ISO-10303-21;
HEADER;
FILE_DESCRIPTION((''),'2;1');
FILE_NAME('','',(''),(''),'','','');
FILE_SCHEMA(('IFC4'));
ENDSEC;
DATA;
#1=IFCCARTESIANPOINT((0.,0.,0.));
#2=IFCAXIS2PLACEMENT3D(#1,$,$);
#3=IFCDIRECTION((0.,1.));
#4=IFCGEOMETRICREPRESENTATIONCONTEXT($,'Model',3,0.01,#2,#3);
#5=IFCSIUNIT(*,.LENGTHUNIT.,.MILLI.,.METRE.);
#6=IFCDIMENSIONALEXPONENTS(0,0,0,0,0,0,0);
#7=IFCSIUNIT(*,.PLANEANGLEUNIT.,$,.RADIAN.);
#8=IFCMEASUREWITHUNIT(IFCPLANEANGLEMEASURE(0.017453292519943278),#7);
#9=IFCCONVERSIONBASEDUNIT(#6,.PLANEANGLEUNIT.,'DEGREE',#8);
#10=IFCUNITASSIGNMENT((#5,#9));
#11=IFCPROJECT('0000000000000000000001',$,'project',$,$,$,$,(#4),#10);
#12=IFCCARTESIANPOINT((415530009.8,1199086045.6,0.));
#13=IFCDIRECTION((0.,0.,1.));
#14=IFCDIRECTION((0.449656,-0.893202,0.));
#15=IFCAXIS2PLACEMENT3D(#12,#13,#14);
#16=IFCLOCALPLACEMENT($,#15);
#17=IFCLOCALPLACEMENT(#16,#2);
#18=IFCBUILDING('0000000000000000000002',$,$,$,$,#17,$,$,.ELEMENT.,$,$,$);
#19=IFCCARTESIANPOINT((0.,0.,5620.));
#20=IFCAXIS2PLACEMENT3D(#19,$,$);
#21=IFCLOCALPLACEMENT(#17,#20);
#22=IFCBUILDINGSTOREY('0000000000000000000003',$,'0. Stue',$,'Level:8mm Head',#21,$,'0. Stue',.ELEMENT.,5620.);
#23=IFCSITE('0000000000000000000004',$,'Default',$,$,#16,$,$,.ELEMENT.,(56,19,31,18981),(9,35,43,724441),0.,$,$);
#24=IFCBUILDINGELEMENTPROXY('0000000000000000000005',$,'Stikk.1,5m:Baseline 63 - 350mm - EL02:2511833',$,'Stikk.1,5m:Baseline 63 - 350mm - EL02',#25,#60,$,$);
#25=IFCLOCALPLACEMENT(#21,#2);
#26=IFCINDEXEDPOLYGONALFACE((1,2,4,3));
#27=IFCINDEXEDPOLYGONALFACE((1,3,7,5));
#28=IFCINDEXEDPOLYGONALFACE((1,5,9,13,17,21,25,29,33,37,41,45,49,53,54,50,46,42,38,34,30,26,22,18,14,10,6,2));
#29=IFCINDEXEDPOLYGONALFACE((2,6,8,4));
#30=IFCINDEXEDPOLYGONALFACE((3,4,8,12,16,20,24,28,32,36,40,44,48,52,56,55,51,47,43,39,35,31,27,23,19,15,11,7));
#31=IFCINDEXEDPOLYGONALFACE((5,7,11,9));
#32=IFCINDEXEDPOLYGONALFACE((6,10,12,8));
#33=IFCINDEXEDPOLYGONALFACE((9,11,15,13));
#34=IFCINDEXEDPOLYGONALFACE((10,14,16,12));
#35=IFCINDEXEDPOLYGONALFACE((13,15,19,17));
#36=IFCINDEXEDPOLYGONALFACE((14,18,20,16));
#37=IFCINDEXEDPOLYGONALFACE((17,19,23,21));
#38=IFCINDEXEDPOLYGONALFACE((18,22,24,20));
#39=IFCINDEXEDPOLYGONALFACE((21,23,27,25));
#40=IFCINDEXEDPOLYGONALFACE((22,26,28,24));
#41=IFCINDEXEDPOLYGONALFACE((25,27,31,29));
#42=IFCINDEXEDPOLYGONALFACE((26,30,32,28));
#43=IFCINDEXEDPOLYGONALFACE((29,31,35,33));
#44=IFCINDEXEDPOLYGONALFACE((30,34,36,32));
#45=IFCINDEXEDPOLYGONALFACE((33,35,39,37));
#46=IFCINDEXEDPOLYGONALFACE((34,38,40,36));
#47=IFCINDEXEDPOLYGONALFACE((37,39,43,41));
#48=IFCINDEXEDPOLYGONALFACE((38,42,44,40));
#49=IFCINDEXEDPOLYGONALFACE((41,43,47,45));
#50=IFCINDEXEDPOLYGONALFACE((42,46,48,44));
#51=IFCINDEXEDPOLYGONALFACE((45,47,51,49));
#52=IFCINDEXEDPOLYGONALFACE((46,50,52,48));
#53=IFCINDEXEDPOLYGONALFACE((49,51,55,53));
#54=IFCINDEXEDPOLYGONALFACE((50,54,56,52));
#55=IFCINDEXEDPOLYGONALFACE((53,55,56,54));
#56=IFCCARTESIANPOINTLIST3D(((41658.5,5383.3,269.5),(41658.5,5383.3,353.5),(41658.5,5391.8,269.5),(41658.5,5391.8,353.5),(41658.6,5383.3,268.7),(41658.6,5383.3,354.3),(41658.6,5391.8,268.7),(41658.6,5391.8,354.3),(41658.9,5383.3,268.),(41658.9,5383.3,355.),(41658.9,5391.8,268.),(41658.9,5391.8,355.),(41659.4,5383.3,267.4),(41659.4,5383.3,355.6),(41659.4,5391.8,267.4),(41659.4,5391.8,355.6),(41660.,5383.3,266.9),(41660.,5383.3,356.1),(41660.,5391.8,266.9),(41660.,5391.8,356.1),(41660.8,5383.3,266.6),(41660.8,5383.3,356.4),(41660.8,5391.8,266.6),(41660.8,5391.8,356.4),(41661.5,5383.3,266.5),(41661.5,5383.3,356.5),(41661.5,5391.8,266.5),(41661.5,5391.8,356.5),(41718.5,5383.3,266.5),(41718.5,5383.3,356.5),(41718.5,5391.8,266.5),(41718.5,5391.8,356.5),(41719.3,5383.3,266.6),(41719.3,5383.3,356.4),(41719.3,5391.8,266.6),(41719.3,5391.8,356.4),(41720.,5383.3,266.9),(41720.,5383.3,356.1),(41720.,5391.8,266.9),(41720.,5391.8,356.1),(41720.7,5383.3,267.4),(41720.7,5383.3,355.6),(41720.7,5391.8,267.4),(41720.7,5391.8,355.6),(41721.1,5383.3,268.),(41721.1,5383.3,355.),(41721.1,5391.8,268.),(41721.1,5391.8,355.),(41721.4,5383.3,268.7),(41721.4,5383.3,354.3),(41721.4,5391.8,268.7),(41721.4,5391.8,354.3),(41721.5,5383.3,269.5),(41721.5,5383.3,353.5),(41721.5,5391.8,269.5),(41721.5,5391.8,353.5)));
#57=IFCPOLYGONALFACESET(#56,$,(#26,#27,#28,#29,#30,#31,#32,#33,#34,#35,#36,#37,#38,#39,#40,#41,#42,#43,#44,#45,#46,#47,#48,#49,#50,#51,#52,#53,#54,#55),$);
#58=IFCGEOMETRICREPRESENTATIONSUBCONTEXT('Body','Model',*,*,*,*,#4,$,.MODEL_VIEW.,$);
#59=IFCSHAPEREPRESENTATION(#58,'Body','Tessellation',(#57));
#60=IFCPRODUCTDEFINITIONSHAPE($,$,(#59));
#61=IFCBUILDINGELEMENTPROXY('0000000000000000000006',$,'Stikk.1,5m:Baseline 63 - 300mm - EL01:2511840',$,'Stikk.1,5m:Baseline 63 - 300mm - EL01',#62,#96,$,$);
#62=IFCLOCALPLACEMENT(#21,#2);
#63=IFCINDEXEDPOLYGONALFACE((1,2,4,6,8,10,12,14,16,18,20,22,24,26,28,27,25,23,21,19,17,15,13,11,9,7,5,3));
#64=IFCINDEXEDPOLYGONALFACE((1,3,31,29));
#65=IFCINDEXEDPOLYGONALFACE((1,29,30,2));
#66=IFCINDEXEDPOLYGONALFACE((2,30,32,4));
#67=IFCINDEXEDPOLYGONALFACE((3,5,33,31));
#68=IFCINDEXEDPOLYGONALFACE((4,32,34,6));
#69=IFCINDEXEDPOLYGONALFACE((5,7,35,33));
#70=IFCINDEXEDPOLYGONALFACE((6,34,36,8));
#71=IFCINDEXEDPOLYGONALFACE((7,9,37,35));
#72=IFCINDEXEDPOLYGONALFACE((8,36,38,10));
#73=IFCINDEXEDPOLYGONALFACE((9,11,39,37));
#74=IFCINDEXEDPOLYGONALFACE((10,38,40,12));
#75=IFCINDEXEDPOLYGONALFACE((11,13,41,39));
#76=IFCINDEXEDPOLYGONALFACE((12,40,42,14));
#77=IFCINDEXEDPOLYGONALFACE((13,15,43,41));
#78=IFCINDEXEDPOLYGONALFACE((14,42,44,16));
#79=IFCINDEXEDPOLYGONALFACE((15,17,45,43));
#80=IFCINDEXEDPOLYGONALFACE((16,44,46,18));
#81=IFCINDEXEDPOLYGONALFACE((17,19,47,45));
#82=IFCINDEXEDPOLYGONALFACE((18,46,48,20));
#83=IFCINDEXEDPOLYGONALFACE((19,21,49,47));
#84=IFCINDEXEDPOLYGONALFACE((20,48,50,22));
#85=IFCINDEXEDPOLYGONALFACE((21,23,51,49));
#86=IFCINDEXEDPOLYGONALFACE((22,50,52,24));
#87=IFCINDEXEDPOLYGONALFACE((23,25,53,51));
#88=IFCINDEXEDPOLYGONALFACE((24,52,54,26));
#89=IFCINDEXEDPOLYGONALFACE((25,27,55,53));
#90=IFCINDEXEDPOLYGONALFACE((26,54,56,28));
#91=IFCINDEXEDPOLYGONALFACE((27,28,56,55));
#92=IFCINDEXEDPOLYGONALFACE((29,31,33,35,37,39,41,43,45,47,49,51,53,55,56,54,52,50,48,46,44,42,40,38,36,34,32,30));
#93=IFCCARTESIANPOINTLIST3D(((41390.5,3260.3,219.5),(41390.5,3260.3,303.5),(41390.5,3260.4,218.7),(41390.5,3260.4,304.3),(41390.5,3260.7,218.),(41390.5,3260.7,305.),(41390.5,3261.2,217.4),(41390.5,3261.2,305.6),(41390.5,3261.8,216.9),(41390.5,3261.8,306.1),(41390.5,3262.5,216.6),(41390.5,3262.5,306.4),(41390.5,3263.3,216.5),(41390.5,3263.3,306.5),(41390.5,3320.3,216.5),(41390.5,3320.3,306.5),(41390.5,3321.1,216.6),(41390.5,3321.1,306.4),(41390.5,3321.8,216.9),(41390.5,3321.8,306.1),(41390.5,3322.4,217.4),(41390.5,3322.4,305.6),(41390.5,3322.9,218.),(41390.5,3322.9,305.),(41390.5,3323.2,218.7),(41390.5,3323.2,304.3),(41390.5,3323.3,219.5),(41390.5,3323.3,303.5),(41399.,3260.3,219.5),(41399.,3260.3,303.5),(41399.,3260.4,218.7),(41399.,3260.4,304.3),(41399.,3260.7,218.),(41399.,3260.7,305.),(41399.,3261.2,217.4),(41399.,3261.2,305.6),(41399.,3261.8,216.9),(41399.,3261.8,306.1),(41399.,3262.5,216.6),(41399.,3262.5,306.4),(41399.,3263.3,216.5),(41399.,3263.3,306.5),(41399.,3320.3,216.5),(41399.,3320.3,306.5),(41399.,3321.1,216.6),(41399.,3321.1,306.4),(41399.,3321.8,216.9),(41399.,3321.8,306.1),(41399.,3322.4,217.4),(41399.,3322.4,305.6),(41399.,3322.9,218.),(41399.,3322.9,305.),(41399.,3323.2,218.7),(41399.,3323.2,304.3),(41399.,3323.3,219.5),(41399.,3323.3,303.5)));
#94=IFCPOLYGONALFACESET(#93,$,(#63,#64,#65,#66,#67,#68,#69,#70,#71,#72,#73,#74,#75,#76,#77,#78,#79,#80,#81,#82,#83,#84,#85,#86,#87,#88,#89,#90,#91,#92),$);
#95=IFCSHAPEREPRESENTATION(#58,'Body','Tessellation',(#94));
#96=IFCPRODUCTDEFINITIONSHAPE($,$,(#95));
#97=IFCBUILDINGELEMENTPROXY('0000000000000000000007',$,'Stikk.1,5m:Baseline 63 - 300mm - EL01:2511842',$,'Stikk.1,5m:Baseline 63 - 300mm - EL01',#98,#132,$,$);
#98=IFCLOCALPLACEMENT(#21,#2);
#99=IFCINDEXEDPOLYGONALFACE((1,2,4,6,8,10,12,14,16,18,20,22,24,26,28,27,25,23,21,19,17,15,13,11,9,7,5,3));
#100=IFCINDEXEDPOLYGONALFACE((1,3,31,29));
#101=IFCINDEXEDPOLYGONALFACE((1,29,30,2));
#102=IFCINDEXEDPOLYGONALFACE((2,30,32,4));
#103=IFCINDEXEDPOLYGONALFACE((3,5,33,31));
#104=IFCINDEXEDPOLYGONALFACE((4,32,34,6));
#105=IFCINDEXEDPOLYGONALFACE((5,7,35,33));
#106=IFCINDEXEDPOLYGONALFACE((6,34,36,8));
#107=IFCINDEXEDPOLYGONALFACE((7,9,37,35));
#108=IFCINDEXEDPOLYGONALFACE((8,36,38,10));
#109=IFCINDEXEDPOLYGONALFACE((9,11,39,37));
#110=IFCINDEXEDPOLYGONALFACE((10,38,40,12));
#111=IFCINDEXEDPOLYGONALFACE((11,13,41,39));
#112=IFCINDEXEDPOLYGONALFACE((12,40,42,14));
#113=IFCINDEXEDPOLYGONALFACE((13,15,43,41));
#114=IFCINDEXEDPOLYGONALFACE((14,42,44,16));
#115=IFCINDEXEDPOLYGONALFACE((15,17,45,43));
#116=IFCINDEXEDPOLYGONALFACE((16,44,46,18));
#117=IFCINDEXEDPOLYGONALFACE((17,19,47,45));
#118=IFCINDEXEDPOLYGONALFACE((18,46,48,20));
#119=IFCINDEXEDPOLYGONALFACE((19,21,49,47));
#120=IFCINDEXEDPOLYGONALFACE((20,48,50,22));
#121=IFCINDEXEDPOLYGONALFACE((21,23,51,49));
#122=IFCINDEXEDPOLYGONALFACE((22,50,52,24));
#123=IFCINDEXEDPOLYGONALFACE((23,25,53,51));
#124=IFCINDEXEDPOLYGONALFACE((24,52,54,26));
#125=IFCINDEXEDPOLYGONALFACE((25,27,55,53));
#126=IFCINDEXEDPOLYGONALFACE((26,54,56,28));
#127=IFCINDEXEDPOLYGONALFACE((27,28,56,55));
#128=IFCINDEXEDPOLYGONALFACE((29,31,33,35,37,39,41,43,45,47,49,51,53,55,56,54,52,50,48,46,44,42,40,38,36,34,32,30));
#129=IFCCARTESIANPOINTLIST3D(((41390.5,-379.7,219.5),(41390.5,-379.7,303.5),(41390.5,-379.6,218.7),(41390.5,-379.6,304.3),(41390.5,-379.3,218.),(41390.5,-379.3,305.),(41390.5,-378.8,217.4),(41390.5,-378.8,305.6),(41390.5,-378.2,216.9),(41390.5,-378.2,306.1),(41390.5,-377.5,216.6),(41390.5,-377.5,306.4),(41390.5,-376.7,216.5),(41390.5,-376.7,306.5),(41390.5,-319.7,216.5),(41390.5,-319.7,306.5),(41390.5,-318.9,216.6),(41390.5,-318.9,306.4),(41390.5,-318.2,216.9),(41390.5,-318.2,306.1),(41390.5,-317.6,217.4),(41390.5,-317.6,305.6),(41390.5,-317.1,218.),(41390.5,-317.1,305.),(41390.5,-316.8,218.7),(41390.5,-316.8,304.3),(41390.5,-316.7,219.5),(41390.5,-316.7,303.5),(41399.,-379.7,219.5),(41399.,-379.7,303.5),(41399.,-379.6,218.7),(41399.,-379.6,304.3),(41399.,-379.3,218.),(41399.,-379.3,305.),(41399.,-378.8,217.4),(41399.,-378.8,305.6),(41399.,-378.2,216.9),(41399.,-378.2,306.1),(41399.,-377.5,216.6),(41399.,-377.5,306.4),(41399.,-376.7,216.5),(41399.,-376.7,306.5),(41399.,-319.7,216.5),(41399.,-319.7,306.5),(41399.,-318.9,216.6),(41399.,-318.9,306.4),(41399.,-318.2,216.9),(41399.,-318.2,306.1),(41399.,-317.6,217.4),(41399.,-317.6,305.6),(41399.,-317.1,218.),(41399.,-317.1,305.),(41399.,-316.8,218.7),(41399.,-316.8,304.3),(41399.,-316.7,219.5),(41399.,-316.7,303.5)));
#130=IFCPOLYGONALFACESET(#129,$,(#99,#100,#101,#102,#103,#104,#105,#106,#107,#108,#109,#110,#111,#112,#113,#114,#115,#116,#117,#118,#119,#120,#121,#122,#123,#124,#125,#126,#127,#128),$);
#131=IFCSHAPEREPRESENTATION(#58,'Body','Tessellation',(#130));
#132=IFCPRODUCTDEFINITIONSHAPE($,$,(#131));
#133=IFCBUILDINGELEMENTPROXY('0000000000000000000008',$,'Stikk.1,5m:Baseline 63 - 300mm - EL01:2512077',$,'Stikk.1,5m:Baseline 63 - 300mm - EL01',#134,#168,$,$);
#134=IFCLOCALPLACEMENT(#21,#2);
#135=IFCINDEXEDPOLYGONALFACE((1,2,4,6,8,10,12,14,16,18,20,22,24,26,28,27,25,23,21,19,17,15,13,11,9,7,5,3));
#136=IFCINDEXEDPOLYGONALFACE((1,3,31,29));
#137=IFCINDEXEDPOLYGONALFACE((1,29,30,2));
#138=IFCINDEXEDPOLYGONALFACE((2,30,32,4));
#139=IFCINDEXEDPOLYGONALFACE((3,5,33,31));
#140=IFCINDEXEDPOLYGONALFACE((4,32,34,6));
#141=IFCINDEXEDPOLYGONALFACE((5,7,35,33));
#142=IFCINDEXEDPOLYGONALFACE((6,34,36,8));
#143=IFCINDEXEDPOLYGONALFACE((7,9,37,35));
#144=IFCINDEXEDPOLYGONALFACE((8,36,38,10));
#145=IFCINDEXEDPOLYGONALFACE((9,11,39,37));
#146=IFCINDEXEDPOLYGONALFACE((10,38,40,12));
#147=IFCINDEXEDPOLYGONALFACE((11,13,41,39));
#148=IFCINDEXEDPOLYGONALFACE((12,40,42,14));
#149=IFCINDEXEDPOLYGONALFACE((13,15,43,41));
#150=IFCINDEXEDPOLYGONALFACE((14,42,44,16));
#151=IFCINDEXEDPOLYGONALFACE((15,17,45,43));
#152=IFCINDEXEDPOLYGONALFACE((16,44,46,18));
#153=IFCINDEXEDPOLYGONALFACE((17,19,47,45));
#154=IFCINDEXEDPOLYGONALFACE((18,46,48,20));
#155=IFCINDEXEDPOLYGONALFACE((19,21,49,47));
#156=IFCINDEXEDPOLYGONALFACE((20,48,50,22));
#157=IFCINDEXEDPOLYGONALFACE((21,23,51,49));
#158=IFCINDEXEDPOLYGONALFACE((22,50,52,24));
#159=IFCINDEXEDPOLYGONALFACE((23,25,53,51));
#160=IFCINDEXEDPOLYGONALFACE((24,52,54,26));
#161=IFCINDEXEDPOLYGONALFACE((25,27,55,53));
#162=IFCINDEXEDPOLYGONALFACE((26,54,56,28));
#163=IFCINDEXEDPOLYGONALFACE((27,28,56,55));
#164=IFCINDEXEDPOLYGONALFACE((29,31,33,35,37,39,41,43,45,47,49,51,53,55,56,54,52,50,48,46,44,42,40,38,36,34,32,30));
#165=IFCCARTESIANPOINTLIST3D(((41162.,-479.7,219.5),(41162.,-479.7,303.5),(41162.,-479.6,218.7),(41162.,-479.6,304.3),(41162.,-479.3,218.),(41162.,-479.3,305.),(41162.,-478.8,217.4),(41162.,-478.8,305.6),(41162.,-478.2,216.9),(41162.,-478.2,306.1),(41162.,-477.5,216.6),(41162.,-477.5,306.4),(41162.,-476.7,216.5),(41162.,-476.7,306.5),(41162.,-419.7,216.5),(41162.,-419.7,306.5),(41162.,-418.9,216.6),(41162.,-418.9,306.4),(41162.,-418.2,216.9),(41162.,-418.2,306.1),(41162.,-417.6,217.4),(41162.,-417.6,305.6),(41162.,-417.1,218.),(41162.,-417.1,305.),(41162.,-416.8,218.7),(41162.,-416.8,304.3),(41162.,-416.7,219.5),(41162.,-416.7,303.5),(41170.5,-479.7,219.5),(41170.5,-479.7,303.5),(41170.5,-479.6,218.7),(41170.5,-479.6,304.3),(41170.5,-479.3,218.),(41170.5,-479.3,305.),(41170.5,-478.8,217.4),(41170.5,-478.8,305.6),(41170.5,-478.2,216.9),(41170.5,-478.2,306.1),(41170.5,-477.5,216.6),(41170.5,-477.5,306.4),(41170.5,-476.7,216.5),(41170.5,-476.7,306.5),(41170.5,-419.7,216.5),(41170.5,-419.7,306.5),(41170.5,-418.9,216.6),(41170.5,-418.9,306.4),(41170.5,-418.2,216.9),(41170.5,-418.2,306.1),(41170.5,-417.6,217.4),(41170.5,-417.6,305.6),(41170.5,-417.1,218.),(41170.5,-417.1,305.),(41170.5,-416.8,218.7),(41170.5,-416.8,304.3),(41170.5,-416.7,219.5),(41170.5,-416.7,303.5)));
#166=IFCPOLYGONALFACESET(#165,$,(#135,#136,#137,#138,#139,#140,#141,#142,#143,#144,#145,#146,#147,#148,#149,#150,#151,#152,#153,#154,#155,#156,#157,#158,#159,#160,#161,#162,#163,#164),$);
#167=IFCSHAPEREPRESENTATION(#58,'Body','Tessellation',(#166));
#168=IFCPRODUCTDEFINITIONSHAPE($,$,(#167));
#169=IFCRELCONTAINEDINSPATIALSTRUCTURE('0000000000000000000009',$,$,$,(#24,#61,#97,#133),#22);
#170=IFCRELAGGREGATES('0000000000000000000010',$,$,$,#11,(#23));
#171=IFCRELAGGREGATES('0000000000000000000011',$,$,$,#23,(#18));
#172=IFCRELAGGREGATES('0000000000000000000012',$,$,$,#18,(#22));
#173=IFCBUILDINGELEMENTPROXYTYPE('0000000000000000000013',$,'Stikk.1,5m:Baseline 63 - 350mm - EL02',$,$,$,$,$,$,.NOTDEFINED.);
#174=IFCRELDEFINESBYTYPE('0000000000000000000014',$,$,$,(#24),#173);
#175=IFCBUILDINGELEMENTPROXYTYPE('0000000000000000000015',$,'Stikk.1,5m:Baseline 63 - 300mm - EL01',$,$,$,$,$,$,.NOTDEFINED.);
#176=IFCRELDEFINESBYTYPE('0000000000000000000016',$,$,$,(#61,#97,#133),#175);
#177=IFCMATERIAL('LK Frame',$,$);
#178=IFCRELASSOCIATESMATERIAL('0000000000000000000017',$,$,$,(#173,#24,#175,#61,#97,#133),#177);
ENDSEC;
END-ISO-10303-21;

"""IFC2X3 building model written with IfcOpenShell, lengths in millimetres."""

from ifc_helpers import new_model, entity, si_unit, converted_unit, direction, frame, frame_2d, origin, place, context, subcontext, project, spatial, polyline, circle_curve, parameter, trimmed, segment, composite_curve, outline, extrude, source, transform, mapped, material, type_object, type_shapes, element, save


model = new_model("IFC2X3")

# Units and contexts
model_context = context("Model", 3, precision=0.01, world=origin(), true_north=direction((0.0, 1.0)))
body_context = subcontext(model_context, "Body", "Model", "MODEL_VIEW")
ifc_project = project(units=[si_unit("LENGTHUNIT", "METRE", prefix="MILLI"), converted_unit("PLANEANGLEUNIT", "DEGREE", entity("IfcPlaneAngleMeasure", 0.017453292519943278), si_unit("PLANEANGLEUNIT", "RADIAN"), dimensions=[0, 0, 0, 0, 0, 0, 0])], contexts=[model_context])

# Site, building, storey
site_placement = place(None, frame((415530009.8, 1199086045.6, 0.0), z_axis=(0.0, 0.0, 1.0), x_axis=(0.449656, -0.893202, 0.0)))
site = spatial("IfcSite", under=ifc_project, at=site_placement, Name="Default", CompositionType="ELEMENT", RefLatitude=(56, 19, 31, 18981), RefLongitude=(9, 35, 43, 724441), RefElevation=0.0)
building_placement = place(site_placement, origin())
building = spatial("IfcBuilding", under=site, at=building_placement, CompositionType="ELEMENT")
storey_placement = place(building_placement, frame((0.0, 0.0, 5620.0)))
storey = spatial("IfcBuildingStorey", under=building, at=storey_placement, Name="0. Stue", ObjectType="Level:8mm Head", LongName="0. Stue", CompositionType="ELEMENT", Elevation=5620.0)

# Building element proxies
ifc_material_1 = material(Name="LK Frame")
building_element_proxy_type_1 = type_object("IfcBuildingElementProxyType", Name="Stikk.1,5m:Baseline 63 - 350mm - EL02", PredefinedType="NOTDEFINED", material=ifc_material_1)
shared_shape_1 = source(origin(), body_context, "Body", "SweptSolid", [
    extrude(outline(composite_curve([segment(trimmed(circle_curve(frame_2d((-42.0, 28.5), x_axis=(1.0, 0.0)), 3.0), [parameter(90.0)], [parameter(180.0)], True, "PARAMETER"), True, "CONTINUOUS"), segment(polyline([(-45.0, 28.5), (-45.0, -28.5)]), True, "CONTINUOUS"), segment(trimmed(circle_curve(frame_2d((-42.0, -28.5), x_axis=(1.0, 0.0)), 3.0), [parameter(180.0)], [parameter(270.0)], True, "PARAMETER"), True, "CONTINUOUS"), segment(polyline([(-42.0, -31.5), (42.0, -31.5)]), True, "CONTINUOUS"), segment(trimmed(circle_curve(frame_2d((42.0, -28.5), x_axis=(-1.0, 0.0)), 3.0), [parameter(90.0)], [parameter(180.0)], True, "PARAMETER"), True, "CONTINUOUS"), segment(polyline([(45.0, -28.5), (45.0, 28.5)]), True, "CONTINUOUS"), segment(trimmed(circle_curve(frame_2d((42.0, 28.5), x_axis=(-1.0, 0.0)), 3.0), [parameter(180.0)], [parameter(270.0)], True, "PARAMETER"), True, "CONTINUOUS"), segment(polyline([(42.0, 31.5), (-42.0, 31.5)]), True, "CONTINUOUS")], self_intersect=False)), frame((0.0, 38.5, 0.0), z_axis=(0.0, 0.0, 1.0), x_axis=(0.0, -1.0, 0.0)), (0.0, 0.0, 1.0), 8.5),
])
type_shapes(building_element_proxy_type_1, [shared_shape_1])
proxy_1_placement = place(storey_placement, frame((41690.0, 5391.8, 350.0), z_axis=(0.0, -1.0, 0.0), x_axis=(-1.0, 0.0, 0.0)))
element("IfcBuildingElementProxy", 1, at=proxy_1_placement, inside=storey, type_object=building_element_proxy_type_1, material=ifc_material_1, Name="Stikk.1,5m:Baseline 63 - 350mm - EL02:2511833", ObjectType="Stikk.1,5m:Baseline 63 - 350mm - EL02", context=body_context, shape_type="MappedRepresentation", body=[
    mapped(shared_shape_1, transform((0.0, 0.0, 0.0), scale=1.0)),
])
building_element_proxy_type_2 = type_object("IfcBuildingElementProxyType", Name="Stikk.1,5m:Baseline 63 - 300mm - EL01", PredefinedType="NOTDEFINED", material=ifc_material_1)
shared_shape_2 = source(origin(), body_context, "Body", "SweptSolid", [
    extrude(outline(composite_curve([segment(trimmed(circle_curve(frame_2d((-42.0, 28.5), x_axis=(1.0, 0.0)), 3.0), [parameter(90.0)], [parameter(180.0)], True, "PARAMETER"), True, "CONTINUOUS"), segment(polyline([(-45.0, 28.5), (-45.0, -28.5)]), True, "CONTINUOUS"), segment(trimmed(circle_curve(frame_2d((-42.0, -28.5), x_axis=(1.0, 0.0)), 3.0), [parameter(180.0)], [parameter(270.0)], True, "PARAMETER"), True, "CONTINUOUS"), segment(polyline([(-42.0, -31.5), (42.0, -31.5)]), True, "CONTINUOUS"), segment(trimmed(circle_curve(frame_2d((42.0, -28.5), x_axis=(-1.0, 0.0)), 3.0), [parameter(90.0)], [parameter(180.0)], True, "PARAMETER"), True, "CONTINUOUS"), segment(polyline([(45.0, -28.5), (45.0, 28.5)]), True, "CONTINUOUS"), segment(trimmed(circle_curve(frame_2d((42.0, 28.5), x_axis=(-1.0, 0.0)), 3.0), [parameter(180.0)], [parameter(270.0)], True, "PARAMETER"), True, "CONTINUOUS"), segment(polyline([(42.0, 31.5), (-42.0, 31.5)]), True, "CONTINUOUS")], self_intersect=False)), frame((0.0, 38.5, 0.0), z_axis=(0.0, 0.0, 1.0), x_axis=(0.0, -1.0, 0.0)), (0.0, 0.0, 1.0), 8.5),
])
type_shapes(building_element_proxy_type_2, [shared_shape_2])
for number, where, z_axis, x_axis, name in (
    (2, (41390.5, 3291.8, 300.0), (1.0, 0.0, 0.0), (0.0, -1.0, 0.0), "Stikk.1,5m:Baseline 63 - 300mm - EL01:2511840"),
    (3, (41390.5, -348.2, 300.0), (1.0, 0.0, 0.0), (0.0, -1.0, 0.0), "Stikk.1,5m:Baseline 63 - 300mm - EL01:2511842"),
    (4, (41170.5, -448.2, 300.0), (-1.0, 0.0, 0.0), (0.0, 1.0, 0.0), "Stikk.1,5m:Baseline 63 - 300mm - EL01:2512077"),
):
    element("IfcBuildingElementProxy", number, at=place(storey_placement, frame(where, z_axis=z_axis, x_axis=x_axis)), inside=storey, type_object=building_element_proxy_type_2, material=ifc_material_1, Name=name, ObjectType="Stikk.1,5m:Baseline 63 - 300mm - EL01", context=body_context, shape_type="MappedRepresentation", body=[
        mapped(shared_shape_2, transform((0.0, 0.0, 0.0), scale=1.0)),
    ])

save(model, "model.ifc")
